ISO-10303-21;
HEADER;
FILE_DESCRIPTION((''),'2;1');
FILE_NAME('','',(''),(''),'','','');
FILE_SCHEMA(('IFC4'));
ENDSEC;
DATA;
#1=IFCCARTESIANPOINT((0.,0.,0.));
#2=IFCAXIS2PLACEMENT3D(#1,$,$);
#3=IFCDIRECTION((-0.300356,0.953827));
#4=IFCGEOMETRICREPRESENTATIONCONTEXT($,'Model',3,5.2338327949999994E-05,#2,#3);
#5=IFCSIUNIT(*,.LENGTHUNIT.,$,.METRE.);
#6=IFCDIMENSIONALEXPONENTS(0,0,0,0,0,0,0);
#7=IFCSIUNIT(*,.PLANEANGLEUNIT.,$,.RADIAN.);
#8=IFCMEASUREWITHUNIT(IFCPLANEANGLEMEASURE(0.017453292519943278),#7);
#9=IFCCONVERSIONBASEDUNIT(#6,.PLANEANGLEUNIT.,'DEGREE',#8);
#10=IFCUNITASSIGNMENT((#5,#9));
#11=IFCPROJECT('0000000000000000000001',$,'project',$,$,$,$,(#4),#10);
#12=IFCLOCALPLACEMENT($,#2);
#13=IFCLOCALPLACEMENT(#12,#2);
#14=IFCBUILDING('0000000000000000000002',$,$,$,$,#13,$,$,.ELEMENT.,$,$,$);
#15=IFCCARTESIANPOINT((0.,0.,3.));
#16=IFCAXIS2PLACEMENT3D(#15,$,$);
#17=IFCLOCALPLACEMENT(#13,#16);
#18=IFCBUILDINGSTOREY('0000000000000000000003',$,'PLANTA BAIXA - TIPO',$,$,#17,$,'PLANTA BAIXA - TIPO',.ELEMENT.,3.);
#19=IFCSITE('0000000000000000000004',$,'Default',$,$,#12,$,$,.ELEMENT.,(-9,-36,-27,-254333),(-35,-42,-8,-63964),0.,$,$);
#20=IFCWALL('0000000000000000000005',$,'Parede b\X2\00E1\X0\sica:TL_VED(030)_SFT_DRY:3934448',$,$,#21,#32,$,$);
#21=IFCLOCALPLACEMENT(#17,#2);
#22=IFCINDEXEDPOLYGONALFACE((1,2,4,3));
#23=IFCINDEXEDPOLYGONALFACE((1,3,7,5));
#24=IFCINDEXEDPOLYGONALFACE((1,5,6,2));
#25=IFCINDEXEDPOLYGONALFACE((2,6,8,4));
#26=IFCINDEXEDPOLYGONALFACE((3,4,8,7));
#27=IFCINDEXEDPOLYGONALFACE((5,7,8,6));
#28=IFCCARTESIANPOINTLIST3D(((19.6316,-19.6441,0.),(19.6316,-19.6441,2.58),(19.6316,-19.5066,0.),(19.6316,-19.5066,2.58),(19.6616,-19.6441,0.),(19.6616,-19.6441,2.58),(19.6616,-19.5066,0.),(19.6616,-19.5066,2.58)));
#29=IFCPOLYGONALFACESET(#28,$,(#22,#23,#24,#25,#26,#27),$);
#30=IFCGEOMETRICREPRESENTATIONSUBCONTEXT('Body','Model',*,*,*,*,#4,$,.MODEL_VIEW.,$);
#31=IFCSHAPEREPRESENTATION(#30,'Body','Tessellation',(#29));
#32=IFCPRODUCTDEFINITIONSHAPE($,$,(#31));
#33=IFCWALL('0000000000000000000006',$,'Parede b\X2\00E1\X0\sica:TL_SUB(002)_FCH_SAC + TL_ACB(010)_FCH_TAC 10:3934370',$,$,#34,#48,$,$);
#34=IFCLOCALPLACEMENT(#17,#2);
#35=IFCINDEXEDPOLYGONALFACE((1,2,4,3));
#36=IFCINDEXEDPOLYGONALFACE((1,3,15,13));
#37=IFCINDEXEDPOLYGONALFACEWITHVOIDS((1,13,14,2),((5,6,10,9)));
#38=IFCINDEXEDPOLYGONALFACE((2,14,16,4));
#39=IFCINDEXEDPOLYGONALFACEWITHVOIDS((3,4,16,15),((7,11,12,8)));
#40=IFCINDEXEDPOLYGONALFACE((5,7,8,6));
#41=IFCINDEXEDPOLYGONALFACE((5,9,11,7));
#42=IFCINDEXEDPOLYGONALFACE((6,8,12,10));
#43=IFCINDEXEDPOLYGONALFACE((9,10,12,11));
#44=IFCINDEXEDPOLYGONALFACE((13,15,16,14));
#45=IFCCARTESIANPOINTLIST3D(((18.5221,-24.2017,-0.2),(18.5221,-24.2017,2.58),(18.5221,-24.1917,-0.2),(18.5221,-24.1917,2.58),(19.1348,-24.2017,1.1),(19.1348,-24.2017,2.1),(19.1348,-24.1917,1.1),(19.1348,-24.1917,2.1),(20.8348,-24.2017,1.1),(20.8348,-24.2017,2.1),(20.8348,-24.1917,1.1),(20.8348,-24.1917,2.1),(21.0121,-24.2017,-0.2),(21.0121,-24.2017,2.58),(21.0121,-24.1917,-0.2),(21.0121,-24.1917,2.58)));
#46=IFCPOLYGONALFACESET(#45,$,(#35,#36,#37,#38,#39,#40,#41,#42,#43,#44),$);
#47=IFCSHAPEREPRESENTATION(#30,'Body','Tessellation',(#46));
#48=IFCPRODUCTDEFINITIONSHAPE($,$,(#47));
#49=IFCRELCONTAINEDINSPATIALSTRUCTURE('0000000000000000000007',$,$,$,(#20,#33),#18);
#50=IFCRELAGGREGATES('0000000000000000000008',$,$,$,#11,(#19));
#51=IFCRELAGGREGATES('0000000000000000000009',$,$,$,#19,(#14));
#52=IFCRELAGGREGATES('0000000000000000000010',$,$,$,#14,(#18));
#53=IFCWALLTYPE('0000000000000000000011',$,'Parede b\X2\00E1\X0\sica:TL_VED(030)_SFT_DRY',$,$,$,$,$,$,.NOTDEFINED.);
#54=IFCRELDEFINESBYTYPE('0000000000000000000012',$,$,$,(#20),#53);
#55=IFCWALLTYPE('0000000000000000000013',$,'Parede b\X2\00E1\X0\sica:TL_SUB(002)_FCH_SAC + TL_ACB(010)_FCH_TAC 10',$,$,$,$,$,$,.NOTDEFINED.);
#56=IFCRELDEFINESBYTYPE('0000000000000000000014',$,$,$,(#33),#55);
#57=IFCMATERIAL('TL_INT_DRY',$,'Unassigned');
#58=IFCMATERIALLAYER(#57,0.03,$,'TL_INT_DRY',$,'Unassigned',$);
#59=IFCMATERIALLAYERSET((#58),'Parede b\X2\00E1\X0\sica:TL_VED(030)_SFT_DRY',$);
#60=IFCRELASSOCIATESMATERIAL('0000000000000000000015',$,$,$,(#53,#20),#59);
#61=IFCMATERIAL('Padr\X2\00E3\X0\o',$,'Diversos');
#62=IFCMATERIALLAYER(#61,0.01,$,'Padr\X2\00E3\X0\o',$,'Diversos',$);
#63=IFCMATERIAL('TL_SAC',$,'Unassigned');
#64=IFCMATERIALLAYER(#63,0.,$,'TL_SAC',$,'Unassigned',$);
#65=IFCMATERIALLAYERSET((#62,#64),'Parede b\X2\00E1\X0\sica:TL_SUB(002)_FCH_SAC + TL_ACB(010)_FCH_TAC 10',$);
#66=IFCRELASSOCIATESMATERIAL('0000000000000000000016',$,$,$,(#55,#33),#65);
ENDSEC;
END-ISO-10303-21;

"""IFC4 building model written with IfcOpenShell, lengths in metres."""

from ifc_helpers import new_model, entity, si_unit, converted_unit, direction, frame, frame_2d, origin, place, context, subcontext, project, spatial, rectangle, extrude, material, layer, layer_set, layer_usage, type_object, element, save


model = new_model("IFC4")

# Units and contexts
model_context = context("Model", 3, precision=5.2338327949999994e-05, world=origin(), true_north=direction((-0.300356, 0.953827)))
body_context = subcontext(model_context, "Body", "Model", "MODEL_VIEW")
ifc_project = project(units=[si_unit("LENGTHUNIT", "METRE"), converted_unit("PLANEANGLEUNIT", "DEGREE", entity("IfcPlaneAngleMeasure", 0.017453292519943278), si_unit("PLANEANGLEUNIT", "RADIAN"), dimensions=[0, 0, 0, 0, 0, 0, 0])], contexts=[model_context])

# Site, building, storey
site_placement = place(None, origin())
site = spatial("IfcSite", under=ifc_project, at=site_placement, Name="Default", CompositionType="ELEMENT", RefLatitude=(-9, -36, -27, -254333), RefLongitude=(-35, -42, -8, -63964), RefElevation=0.0)
building_placement = place(site_placement, origin())
building = spatial("IfcBuilding", under=site, at=building_placement, CompositionType="ELEMENT")
storey_placement = place(building_placement, frame((0.0, 0.0, 3.0)))
storey = spatial("IfcBuildingStorey", under=building, at=storey_placement, Name="PLANTA BAIXA - TIPO", LongName="PLANTA BAIXA - TIPO", CompositionType="ELEMENT", Elevation=3.0)

# Shared definitions
ifc_material_1 = material(Name="TL_SAC", Category="Unassigned")

# Wall
ifc_material_2 = material(Name="TL_INT_DRY", Category="Unassigned")
ifc_layer_1 = layer(ifc_material_2, 0.03, Name="TL_INT_DRY", Category="Unassigned")
ifc_layer_set_1 = layer_set([ifc_layer_1], Name="Parede básica:TL_VED(030)_SFT_DRY")
wall_type_1 = type_object("IfcWallType", Name="Parede básica:TL_VED(030)_SFT_DRY", PredefinedType="NOTDEFINED", material=ifc_layer_set_1)
ifc_layer_usage_1 = layer_usage(ifc_layer_set_1, "AXIS2", "NEGATIVE", 0.015)
wall_1_placement = place(storey_placement, frame((19.6466, -19.6441, 0.0), z_axis=(0.0, 0.0, 1.0), x_axis=(0.0, 1.0, 0.0)))
element("IfcWall", 1, at=wall_1_placement, inside=storey, type_object=wall_type_1, material=ifc_layer_usage_1, Name="Parede básica:TL_VED(030)_SFT_DRY:3934448", context=body_context, shape_type="SweptSolid", body=[
    extrude(rectangle(XDim=0.1375, YDim=0.03, at=frame_2d((0.0688, 0.0), x_axis=(-1.0, 0.0))), origin(), (0.0, 0.0, 1.0), 2.58),
])

# Wall, opening
ifc_material_3 = material(Name="Padrão", Category="Diversos")
ifc_layer_2 = layer(ifc_material_3, 0.01, Name="Padrão", Category="Diversos")
ifc_layer_3 = layer(ifc_material_1, 0.0, Name="TL_SAC", Category="Unassigned")
ifc_layer_set_2 = layer_set([ifc_layer_2, ifc_layer_3], Name="Parede básica:TL_SUB(002)_FCH_SAC + TL_ACB(010)_FCH_TAC 10")
ifc_layer_usage_2 = layer_usage(ifc_layer_set_2, "AXIS2", "NEGATIVE", 0.005)
wall_type_2 = type_object("IfcWallType", Name="Parede básica:TL_SUB(002)_FCH_SAC + TL_ACB(010)_FCH_TAC 10", PredefinedType="NOTDEFINED", material=ifc_layer_set_2)
wall_2_placement = place(storey_placement, frame((18.5221, -24.1967, -0.2)))
wall_2 = element("IfcWall", 2, at=wall_2_placement, inside=storey, type_object=wall_type_2, material=ifc_layer_usage_2, Name="Parede básica:TL_SUB(002)_FCH_SAC + TL_ACB(010)_FCH_TAC 10:3934370", context=body_context, shape_type="SweptSolid", body=[
    extrude(rectangle(XDim=2.49, YDim=0.01, at=frame_2d((1.245, 0.0), x_axis=(-1.0, 0.0))), origin(), (0.0, 0.0, 1.0), 2.78),
])
opening_1_placement = place(wall_2_placement, frame((-18.5221, 24.1967, 1.3)))
element("IfcOpeningElement", 3, at=opening_1_placement, cuts=wall_2, PredefinedType="OPENING", context=body_context, shape_type="SweptSolid", body=[
    extrude(rectangle(XDim=1.0, YDim=1.7, at=frame_2d((0.0, 0.0), x_axis=(0.0, 1.0))), frame((19.9848, -25.6157, 0.5), z_axis=(0.0, 1.0, 0.0), x_axis=(1.0, 0.0, 0.0)), (0.0, 0.0, 1.0), 3.048),
])

save(model, "model.ifc")
